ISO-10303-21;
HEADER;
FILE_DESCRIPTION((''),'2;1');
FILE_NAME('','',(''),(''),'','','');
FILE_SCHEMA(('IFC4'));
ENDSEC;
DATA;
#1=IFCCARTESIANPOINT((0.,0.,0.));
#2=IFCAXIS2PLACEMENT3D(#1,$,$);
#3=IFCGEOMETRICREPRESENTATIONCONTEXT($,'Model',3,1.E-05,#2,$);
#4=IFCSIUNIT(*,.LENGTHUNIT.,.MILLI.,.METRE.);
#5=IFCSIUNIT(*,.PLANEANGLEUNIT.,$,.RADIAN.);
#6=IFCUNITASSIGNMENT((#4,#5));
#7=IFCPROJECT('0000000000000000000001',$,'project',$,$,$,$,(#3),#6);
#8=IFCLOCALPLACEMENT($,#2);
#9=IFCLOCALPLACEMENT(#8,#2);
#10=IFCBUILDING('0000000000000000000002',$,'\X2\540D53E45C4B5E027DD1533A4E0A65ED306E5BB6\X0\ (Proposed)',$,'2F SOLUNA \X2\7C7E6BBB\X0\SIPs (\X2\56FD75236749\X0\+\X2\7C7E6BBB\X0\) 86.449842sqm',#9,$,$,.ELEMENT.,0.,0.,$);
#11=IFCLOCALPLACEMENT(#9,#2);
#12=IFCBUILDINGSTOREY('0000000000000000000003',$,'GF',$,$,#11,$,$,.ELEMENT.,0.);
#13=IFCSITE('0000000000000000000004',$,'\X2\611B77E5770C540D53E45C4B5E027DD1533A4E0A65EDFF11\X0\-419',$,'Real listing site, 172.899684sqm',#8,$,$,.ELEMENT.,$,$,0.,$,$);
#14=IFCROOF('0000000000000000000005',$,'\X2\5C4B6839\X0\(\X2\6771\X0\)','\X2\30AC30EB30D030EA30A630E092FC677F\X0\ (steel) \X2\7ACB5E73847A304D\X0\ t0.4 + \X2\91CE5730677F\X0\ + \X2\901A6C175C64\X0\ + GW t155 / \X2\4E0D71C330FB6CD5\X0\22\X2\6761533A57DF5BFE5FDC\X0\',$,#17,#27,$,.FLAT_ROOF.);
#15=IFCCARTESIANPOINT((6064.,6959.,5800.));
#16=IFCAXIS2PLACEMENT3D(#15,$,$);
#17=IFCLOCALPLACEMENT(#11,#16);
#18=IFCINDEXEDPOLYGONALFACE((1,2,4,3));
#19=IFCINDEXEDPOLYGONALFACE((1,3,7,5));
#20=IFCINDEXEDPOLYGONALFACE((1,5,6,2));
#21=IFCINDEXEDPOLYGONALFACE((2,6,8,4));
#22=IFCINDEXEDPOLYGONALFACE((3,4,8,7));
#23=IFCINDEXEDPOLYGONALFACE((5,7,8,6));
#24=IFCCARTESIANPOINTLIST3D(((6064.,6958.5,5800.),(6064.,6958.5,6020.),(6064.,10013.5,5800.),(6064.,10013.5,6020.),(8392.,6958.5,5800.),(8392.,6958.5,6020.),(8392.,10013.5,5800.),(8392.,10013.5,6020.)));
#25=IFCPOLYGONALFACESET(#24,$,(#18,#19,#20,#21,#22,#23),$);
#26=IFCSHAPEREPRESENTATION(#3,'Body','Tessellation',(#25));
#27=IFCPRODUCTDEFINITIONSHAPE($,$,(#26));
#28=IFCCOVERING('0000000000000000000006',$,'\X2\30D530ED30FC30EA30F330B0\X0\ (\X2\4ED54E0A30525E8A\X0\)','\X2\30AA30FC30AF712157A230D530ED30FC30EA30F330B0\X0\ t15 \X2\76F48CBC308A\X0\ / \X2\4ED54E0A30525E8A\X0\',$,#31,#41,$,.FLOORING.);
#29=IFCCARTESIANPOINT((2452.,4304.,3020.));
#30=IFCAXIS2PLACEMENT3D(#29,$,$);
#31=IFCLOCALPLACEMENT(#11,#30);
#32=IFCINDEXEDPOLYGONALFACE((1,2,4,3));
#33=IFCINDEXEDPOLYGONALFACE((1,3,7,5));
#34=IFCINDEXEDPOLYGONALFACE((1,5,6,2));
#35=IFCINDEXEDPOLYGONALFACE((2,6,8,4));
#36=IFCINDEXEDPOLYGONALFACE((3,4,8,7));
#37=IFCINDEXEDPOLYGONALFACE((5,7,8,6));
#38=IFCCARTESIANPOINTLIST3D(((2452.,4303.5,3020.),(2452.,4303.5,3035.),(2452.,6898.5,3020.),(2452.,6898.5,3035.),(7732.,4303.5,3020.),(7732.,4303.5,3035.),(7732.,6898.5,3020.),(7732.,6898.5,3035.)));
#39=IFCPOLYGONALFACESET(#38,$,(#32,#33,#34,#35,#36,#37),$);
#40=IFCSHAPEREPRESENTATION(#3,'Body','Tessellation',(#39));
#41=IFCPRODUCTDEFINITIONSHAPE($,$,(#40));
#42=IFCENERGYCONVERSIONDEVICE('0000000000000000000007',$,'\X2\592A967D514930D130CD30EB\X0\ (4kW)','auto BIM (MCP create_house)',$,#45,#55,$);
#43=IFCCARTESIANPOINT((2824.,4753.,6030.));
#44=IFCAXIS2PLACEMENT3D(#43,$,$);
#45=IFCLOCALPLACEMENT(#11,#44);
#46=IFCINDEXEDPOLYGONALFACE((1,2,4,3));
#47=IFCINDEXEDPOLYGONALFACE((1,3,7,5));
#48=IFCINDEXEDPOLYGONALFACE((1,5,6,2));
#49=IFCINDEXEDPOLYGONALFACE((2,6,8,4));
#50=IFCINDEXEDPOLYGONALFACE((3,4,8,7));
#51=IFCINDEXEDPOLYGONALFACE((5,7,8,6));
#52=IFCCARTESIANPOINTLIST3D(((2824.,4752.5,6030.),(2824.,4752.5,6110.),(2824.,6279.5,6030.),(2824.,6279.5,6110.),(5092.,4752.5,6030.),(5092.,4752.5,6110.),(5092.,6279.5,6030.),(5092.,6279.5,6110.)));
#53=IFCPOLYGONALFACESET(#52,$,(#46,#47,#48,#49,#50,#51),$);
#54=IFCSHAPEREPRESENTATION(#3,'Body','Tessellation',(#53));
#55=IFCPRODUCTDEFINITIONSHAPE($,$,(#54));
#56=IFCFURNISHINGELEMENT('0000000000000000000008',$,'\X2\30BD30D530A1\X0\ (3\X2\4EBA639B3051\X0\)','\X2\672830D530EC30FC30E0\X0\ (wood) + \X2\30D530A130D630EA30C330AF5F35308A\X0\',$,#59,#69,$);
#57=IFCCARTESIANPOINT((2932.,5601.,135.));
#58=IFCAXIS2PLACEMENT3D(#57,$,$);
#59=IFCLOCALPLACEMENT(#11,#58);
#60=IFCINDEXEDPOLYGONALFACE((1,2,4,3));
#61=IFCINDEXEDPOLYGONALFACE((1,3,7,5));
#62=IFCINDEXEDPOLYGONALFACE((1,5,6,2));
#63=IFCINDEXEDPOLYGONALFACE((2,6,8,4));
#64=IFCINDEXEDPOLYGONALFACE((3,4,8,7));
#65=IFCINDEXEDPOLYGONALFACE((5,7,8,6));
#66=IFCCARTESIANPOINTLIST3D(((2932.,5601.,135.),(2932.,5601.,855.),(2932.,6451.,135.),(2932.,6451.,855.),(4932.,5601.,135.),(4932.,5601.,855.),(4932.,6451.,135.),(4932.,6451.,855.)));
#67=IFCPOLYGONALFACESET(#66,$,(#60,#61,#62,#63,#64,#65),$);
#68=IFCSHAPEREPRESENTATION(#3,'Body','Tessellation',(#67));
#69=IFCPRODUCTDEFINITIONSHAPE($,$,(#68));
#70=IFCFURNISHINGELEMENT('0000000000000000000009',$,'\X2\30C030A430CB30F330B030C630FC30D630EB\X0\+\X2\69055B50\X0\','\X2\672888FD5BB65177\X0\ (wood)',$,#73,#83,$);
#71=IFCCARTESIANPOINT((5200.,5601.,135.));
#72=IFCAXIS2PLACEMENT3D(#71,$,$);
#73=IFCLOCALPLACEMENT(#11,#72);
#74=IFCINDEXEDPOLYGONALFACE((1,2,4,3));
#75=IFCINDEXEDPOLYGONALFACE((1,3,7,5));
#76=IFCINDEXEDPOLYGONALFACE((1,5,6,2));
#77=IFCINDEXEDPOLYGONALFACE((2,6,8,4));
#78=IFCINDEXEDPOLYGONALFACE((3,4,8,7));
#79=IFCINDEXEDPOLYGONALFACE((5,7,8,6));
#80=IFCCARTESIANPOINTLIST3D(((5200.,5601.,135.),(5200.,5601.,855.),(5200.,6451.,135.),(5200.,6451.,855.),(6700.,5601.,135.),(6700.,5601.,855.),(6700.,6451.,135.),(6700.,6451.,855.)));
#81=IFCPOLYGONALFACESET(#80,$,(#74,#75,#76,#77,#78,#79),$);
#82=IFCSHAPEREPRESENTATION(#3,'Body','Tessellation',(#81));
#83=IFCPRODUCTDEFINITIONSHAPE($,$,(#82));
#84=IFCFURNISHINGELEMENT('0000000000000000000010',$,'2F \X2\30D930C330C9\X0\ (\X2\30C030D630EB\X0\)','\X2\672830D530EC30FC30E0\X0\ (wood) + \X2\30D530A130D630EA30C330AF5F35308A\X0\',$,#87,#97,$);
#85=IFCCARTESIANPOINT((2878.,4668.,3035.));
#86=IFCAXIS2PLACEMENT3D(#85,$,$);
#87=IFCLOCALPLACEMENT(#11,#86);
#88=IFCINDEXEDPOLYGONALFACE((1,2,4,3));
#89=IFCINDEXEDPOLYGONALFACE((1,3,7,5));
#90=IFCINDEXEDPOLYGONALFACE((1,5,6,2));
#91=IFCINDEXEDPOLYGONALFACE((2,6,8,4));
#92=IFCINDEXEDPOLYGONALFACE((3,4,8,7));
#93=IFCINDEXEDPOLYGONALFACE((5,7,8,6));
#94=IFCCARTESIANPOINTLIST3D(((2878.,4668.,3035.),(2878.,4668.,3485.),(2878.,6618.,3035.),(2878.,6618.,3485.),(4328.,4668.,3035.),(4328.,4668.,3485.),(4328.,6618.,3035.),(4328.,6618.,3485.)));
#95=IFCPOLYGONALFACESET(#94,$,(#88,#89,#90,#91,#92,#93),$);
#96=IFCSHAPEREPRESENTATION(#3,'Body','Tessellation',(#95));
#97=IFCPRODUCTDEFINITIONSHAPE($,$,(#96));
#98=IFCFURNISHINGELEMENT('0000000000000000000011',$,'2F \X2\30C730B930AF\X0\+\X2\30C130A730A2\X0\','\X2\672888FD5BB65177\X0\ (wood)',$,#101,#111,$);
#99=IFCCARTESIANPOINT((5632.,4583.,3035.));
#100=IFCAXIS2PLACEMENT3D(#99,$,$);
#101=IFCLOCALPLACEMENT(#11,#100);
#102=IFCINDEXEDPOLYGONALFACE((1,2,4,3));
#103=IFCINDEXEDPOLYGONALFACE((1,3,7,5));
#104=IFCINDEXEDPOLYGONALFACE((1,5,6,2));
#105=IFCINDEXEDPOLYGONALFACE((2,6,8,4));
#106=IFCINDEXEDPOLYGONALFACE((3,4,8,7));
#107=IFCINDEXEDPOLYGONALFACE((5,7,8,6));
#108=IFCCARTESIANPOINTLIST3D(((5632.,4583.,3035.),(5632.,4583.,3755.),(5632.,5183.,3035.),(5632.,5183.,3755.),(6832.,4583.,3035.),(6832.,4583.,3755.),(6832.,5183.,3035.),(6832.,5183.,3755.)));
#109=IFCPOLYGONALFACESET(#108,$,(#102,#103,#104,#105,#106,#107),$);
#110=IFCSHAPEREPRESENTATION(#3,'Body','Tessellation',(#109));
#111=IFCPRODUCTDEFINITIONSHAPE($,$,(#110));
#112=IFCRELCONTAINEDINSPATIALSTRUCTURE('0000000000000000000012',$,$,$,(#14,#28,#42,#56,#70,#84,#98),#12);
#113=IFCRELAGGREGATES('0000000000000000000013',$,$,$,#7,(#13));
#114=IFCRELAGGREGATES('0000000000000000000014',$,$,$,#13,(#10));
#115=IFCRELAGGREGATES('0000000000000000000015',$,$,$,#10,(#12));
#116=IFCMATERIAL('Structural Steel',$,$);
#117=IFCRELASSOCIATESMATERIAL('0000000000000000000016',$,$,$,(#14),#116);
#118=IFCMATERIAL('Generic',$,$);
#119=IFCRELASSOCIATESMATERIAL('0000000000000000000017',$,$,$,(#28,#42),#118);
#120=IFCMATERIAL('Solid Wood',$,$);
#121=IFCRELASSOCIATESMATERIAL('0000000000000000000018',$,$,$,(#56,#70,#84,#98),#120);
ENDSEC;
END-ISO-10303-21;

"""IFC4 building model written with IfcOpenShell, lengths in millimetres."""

from ifc_helpers import new_model, si_unit, frame, frame_2d, origin, place, context, project, spatial, rectangle, extrude, material, element, save


model = new_model("IFC4")

# Units and contexts
model_context = context("Model", 3, precision=1e-05, world=origin())
ifc_project = project(units=[si_unit("LENGTHUNIT", "METRE", prefix="MILLI"), si_unit("PLANEANGLEUNIT", "RADIAN")], contexts=[model_context])

# Site, building, storey
site_placement = place(None, origin())
site = spatial("IfcSite", under=ifc_project, at=site_placement, Name="愛知県名古屋市緑区上旭１-419", ObjectType="Real listing site, 172.899684sqm", CompositionType="ELEMENT", RefElevation=0.0)
building_placement = place(site_placement, origin())
building = spatial("IfcBuilding", under=site, at=building_placement, Name="名古屋市緑区上旭の家 (Proposed)", ObjectType="2F SOLUNA 籾殻SIPs (国産杉+籾殻) 86.449842sqm", CompositionType="ELEMENT", ElevationOfRefHeight=0.0, ElevationOfTerrain=0.0)
storey_placement = place(building_placement, origin())
storey = spatial("IfcBuildingStorey", under=building, at=storey_placement, Name="GF", CompositionType="ELEMENT", Elevation=0.0)

# Shared definitions
ifc_material_1 = material(Name="Solid Wood")

# Roof
ifc_material_2 = material(Name="Structural Steel")
roof_1_placement = place(storey_placement, frame((6064.0, 6959.0, 5800.0)))
element("IfcRoof", 1, at=roof_1_placement, inside=storey, material=ifc_material_2, Name="屋根(東)", Description="ガルバリウム鋼板 (steel) 立平葺き t0.4 + 野地板 + 通気層 + GW t155 / 不燃・法22条区域対応", PredefinedType="FLAT_ROOF", context=model_context, shape_type="SweptSolid", body=[
    extrude(rectangle(XDim=2328.0, YDim=3055.0, at=frame_2d((1164.0, 1527.0))), frame((6064.0, 6959.0, 5800.0)), (0.0, 0.0, 1.0), 220.0),
])

# Covering
ifc_material_3 = material(Name="Generic")
covering_placement = place(storey_placement, frame((2452.0, 4304.0, 3020.0)))
element("IfcCovering", 2, at=covering_placement, inside=storey, material=ifc_material_3, Name="フローリング (仕上げ床)", Description="オーク無垢フローリング t15 直貼り / 仕上げ床", PredefinedType="FLOORING", context=model_context, shape_type="SweptSolid", body=[
    extrude(rectangle(XDim=5280.0, YDim=2595.0, at=frame_2d((2640.0, 1297.0))), frame((2452.0, 4304.0, 3020.0)), (0.0, 0.0, 1.0), 15.0),
])

# Energy conversion device
energy_conversion_device_placement = place(storey_placement, frame((2824.0, 4753.0, 6030.0)))
element("IfcEnergyConversionDevice", 3, at=energy_conversion_device_placement, inside=storey, material=ifc_material_3, Name="太陽光パネル (4kW)", Description="auto BIM (MCP create_house)", context=model_context, shape_type="SweptSolid", body=[
    extrude(rectangle(XDim=2268.0, YDim=1527.0, at=frame_2d((1134.0, 763.0))), frame((2824.0, 4753.0, 6030.0)), (0.0, 0.0, 1.0), 80.0),
])

# Furnishing elements
furnishing_1_placement = place(storey_placement, frame((2932.0, 5601.0, 135.0)))
element("IfcFurnishingElement", 4, at=furnishing_1_placement, inside=storey, material=ifc_material_1, Name="ソファ (3人掛け)", Description="木フレーム (wood) + ファブリック張り", context=model_context, shape_type="SweptSolid", body=[
    extrude(rectangle(XDim=2000.0, YDim=850.0, at=frame_2d((1000.0, 425.0))), frame((2932.0, 5601.0, 135.0)), (0.0, 0.0, 1.0), 720.0),
])
furnishing_2_placement = place(storey_placement, frame((5200.0, 5601.0, 135.0)))
element("IfcFurnishingElement", 5, at=furnishing_2_placement, inside=storey, material=ifc_material_1, Name="ダイニングテーブル+椅子", Description="木製家具 (wood)", context=model_context, shape_type="SweptSolid", body=[
    extrude(rectangle(XDim=1500.0, YDim=850.0, at=frame_2d((750.0, 425.0))), frame((5200.0, 5601.0, 135.0)), (0.0, 0.0, 1.0), 720.0),
])
furnishing_3_placement = place(storey_placement, frame((2878.0, 4668.0, 3035.0)))
element("IfcFurnishingElement", 6, at=furnishing_3_placement, inside=storey, material=ifc_material_1, Name="2F ベッド (ダブル)", Description="木フレーム (wood) + ファブリック張り", context=model_context, shape_type="SweptSolid", body=[
    extrude(rectangle(XDim=1450.0, YDim=1950.0, at=frame_2d((725.0, 975.0))), frame((2878.0, 4668.0, 3035.0)), (0.0, 0.0, 1.0), 450.0),
])
furnishing_4_placement = place(storey_placement, frame((5632.0, 4583.0, 3035.0)))
element("IfcFurnishingElement", 7, at=furnishing_4_placement, inside=storey, material=ifc_material_1, Name="2F デスク+チェア", Description="木製家具 (wood)", context=model_context, shape_type="SweptSolid", body=[
    extrude(rectangle(XDim=1200.0, YDim=600.0, at=frame_2d((600.0, 300.0))), frame((5632.0, 4583.0, 3035.0)), (0.0, 0.0, 1.0), 720.0),
])

save(model, "model.ifc")
